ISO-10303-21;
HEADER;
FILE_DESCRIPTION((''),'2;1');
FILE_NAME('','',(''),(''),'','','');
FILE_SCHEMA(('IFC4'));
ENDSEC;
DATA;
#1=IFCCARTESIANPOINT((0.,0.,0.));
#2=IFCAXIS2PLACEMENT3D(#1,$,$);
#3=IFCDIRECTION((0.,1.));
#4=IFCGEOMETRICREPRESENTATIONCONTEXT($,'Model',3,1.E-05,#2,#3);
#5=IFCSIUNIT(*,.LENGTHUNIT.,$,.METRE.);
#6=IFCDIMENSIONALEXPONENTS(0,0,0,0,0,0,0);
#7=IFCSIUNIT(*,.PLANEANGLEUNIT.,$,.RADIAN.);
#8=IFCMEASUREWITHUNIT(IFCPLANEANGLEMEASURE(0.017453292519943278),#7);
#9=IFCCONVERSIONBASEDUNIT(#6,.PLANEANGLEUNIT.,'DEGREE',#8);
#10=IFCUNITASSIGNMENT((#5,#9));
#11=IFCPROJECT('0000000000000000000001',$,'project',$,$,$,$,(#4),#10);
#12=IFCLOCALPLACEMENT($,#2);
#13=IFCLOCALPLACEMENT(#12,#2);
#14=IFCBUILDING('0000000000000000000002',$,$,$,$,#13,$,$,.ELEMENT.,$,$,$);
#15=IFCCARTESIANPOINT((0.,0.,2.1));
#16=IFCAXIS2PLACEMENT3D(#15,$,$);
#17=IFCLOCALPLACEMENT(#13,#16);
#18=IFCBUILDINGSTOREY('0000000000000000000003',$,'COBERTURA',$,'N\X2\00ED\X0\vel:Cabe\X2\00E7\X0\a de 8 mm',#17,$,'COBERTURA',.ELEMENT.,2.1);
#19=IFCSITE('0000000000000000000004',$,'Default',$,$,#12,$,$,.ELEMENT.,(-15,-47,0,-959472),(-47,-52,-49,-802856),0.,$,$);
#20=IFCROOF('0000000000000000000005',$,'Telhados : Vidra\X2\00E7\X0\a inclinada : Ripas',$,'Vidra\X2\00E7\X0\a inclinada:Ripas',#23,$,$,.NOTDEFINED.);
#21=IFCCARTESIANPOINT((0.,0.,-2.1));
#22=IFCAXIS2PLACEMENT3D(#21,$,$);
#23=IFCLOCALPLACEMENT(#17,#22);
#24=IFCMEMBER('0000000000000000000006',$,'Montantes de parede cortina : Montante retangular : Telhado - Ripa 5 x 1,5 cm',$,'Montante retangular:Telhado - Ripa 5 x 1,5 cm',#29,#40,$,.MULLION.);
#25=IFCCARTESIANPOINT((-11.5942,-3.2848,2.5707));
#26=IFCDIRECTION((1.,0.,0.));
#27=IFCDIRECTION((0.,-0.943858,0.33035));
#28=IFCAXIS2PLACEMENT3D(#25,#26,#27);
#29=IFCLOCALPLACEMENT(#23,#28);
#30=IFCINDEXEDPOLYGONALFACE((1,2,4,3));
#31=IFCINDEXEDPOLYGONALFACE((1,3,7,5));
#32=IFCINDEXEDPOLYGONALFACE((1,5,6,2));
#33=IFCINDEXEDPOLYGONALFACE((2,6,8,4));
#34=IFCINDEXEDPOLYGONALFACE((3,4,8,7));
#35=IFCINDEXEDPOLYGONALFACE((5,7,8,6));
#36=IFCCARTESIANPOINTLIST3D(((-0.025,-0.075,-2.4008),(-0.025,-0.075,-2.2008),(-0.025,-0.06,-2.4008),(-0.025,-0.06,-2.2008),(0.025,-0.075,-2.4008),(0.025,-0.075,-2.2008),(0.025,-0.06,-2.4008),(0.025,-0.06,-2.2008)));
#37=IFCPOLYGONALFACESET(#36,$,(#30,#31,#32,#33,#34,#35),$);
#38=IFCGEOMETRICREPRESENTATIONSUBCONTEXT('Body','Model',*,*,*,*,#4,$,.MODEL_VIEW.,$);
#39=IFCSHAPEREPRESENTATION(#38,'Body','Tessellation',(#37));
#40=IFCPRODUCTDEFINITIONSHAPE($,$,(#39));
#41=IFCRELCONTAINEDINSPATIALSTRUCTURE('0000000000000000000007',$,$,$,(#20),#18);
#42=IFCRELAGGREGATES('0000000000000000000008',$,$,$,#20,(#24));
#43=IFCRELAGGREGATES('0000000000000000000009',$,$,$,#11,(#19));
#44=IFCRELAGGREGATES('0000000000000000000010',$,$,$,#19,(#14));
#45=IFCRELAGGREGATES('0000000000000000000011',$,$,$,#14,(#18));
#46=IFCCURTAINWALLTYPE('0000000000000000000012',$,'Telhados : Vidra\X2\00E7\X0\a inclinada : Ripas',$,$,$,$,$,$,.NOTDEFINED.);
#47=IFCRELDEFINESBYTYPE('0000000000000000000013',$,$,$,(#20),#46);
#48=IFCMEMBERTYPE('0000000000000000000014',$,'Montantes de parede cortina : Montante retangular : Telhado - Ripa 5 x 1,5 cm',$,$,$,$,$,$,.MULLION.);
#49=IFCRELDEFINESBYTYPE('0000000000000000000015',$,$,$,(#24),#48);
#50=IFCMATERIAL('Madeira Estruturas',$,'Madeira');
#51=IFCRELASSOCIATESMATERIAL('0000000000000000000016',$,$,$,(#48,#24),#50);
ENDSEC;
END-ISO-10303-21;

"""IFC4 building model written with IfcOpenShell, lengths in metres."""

from ifc_helpers import new_model, entity, si_unit, converted_unit, direction, frame, origin, place, context, subcontext, project, spatial, indexed_curve, outline, extrude, source, transform, mapped, material, type_object, type_shapes, element, aggregate, save


model = new_model("IFC4")

# Units and contexts
model_context = context("Model", 3, precision=1e-05, world=origin(), true_north=direction((0.0, 1.0)))
body_context = subcontext(model_context, "Body", "Model", "MODEL_VIEW")
ifc_project = project(units=[si_unit("LENGTHUNIT", "METRE"), converted_unit("PLANEANGLEUNIT", "DEGREE", entity("IfcPlaneAngleMeasure", 0.017453292519943278), si_unit("PLANEANGLEUNIT", "RADIAN"), dimensions=[0, 0, 0, 0, 0, 0, 0])], contexts=[model_context])

# Site, building, storey
site_placement = place(None, origin())
site = spatial("IfcSite", under=ifc_project, at=site_placement, Name="Default", CompositionType="ELEMENT", RefLatitude=(-15, -47, 0, -959472), RefLongitude=(-47, -52, -49, -802856), RefElevation=0.0)
building_placement = place(site_placement, origin())
building = spatial("IfcBuilding", under=site, at=building_placement, CompositionType="ELEMENT")
storey_placement = place(building_placement, frame((0.0, 0.0, 2.1)))
storey = spatial("IfcBuildingStorey", under=building, at=storey_placement, Name="COBERTURA", ObjectType="Nível:Cabeça de 8 mm", LongName="COBERTURA", CompositionType="ELEMENT", Elevation=2.1)

# Roof, member
curtain_wall_type_1 = type_object("IfcCurtainWallType", Name="Telhados : Vidraça inclinada : Ripas", PredefinedType="NOTDEFINED")
roof_1_placement = place(storey_placement, frame((0.0, 0.0, -2.1)))
roof_1 = element("IfcRoof", 1, at=roof_1_placement, inside=storey, type_object=curtain_wall_type_1, Name="Telhados : Vidraça inclinada : Ripas", ObjectType="Vidraça inclinada:Ripas", PredefinedType="NOTDEFINED")
ifc_material_1 = material(Name="Madeira Estruturas", Category="Madeira")
member_type_1 = type_object("IfcMemberType", Name="Montantes de parede cortina : Montante retangular : Telhado - Ripa 5 x 1,5 cm", PredefinedType="MULLION", material=ifc_material_1)
shared_shape_1 = source(origin(), body_context, "Body", "SweptSolid", [
    extrude(outline(indexed_curve([(-0.025, -0.0075), (0.025, -0.0075), (0.025, 0.0075), (-0.025, 0.0075), (-0.025, -0.0075)], self_intersect=False)), frame((0.0, -0.0675, -2.4008), z_axis=(0.0, 0.0, 1.0), x_axis=(-1.0, 0.0, 0.0)), (0.0, 0.0, 1.0), 0.2),
])
type_shapes(member_type_1, [shared_shape_1])
member_1_placement = place(roof_1_placement, frame((-11.5942, -3.2848, 2.5707), z_axis=(1.0, 0.0, 0.0), x_axis=(0.0, -0.943858, 0.33035)))
member_1 = element("IfcMember", 2, at=member_1_placement, type_object=member_type_1, material=ifc_material_1, Name="Montantes de parede cortina : Montante retangular : Telhado - Ripa 5 x 1,5 cm", ObjectType="Montante retangular:Telhado - Ripa 5 x 1,5 cm", PredefinedType="MULLION", context=body_context, shape_type="MappedRepresentation", body=[
    mapped(shared_shape_1, transform((0.0, 0.0, 0.0), scale=1.0)),
])
aggregate(roof_1, [member_1])

save(model, "model.ifc")
